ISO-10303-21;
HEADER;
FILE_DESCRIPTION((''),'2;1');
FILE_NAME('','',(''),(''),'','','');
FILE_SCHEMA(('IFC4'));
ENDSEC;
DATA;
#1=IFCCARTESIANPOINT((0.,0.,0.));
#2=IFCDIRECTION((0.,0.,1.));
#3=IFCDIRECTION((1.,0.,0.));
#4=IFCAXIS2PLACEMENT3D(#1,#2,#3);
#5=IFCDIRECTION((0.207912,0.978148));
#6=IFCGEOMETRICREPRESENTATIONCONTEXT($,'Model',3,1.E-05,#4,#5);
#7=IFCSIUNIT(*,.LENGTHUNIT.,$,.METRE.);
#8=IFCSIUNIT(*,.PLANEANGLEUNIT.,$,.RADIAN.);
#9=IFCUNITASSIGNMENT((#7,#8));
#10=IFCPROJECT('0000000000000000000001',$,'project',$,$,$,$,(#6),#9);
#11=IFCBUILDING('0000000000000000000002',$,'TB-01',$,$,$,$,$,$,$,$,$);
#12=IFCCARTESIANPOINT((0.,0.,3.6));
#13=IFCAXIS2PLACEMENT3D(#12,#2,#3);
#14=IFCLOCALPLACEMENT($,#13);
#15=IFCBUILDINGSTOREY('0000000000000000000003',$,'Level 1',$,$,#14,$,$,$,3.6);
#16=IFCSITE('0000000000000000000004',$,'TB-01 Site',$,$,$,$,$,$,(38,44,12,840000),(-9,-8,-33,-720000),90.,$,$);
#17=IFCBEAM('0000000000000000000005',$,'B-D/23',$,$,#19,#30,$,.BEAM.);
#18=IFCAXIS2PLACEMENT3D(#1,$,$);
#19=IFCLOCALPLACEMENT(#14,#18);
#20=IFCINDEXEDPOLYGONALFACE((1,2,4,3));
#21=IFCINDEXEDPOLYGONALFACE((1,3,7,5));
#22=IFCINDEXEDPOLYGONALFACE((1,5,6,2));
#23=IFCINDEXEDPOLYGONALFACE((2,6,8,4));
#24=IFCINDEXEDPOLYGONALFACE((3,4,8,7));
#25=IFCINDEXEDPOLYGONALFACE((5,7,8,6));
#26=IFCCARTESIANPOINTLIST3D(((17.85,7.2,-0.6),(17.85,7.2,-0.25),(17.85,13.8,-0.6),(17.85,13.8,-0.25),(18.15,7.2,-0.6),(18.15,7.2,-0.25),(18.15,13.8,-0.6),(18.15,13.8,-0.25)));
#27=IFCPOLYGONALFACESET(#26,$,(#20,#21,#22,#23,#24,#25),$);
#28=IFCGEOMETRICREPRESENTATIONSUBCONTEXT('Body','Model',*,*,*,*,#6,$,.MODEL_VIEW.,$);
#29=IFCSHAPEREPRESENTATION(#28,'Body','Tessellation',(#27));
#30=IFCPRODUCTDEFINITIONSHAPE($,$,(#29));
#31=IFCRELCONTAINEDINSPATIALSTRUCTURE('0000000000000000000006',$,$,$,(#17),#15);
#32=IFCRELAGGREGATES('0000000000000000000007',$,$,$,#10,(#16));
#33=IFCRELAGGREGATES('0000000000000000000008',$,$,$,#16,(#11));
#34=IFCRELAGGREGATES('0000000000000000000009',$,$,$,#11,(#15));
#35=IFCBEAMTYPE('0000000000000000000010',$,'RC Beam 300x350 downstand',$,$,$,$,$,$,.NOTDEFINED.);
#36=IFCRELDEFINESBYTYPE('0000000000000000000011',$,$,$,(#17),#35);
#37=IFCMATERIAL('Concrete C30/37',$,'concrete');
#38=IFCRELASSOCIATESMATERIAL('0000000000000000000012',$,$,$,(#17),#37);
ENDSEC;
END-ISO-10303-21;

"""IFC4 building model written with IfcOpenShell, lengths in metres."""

from ifc_helpers import new_model, si_unit, direction, frame, origin_with_axes, place, context, subcontext, project, spatial, rectangle, extrude, material, type_object, element, save


model = new_model("IFC4")

# Units and contexts
model_context = context("Model", 3, precision=1e-05, world=origin_with_axes(), true_north=direction((0.207912, 0.978148)))
body_context = subcontext(model_context, "Body", "Model", "MODEL_VIEW")
ifc_project = project(units=[si_unit("LENGTHUNIT", "METRE"), si_unit("PLANEANGLEUNIT", "RADIAN")], contexts=[model_context])

# Site, building, storey
site = spatial("IfcSite", under=ifc_project, Name="TB-01 Site", RefLatitude=(38, 44, 12, 840000), RefLongitude=(-9, -8, -33, -720000), RefElevation=90.0)
building = spatial("IfcBuilding", under=site, Name="TB-01")
storey_placement = place(None, frame((0.0, 0.0, 3.6), z_axis=(0.0, 0.0, 1.0), x_axis=(1.0, 0.0, 0.0)))
storey = spatial("IfcBuildingStorey", under=building, at=storey_placement, Name="Level 1", Elevation=3.6)

# Beam
ifc_material = material(Name="Concrete C30/37", Category="concrete")
beam_type = type_object("IfcBeamType", Name="RC Beam 300x350 downstand", PredefinedType="NOTDEFINED")
beam_1_placement = place(storey_placement, frame((18.0, 7.2, -0.425), z_axis=(0.0, 1.0, 0.0), x_axis=(-1.0, 0.0, 0.0)))
element("IfcBeam", 1, at=beam_1_placement, inside=storey, type_object=beam_type, material=ifc_material, Name="B-D/23", PredefinedType="BEAM", context=body_context, shape_type="SweptSolid", body=[
    extrude(rectangle(XDim=0.3, YDim=0.35), origin_with_axes(), (0.0, 0.0, 1.0), 6.6),
])

save(model, "model.ifc")
